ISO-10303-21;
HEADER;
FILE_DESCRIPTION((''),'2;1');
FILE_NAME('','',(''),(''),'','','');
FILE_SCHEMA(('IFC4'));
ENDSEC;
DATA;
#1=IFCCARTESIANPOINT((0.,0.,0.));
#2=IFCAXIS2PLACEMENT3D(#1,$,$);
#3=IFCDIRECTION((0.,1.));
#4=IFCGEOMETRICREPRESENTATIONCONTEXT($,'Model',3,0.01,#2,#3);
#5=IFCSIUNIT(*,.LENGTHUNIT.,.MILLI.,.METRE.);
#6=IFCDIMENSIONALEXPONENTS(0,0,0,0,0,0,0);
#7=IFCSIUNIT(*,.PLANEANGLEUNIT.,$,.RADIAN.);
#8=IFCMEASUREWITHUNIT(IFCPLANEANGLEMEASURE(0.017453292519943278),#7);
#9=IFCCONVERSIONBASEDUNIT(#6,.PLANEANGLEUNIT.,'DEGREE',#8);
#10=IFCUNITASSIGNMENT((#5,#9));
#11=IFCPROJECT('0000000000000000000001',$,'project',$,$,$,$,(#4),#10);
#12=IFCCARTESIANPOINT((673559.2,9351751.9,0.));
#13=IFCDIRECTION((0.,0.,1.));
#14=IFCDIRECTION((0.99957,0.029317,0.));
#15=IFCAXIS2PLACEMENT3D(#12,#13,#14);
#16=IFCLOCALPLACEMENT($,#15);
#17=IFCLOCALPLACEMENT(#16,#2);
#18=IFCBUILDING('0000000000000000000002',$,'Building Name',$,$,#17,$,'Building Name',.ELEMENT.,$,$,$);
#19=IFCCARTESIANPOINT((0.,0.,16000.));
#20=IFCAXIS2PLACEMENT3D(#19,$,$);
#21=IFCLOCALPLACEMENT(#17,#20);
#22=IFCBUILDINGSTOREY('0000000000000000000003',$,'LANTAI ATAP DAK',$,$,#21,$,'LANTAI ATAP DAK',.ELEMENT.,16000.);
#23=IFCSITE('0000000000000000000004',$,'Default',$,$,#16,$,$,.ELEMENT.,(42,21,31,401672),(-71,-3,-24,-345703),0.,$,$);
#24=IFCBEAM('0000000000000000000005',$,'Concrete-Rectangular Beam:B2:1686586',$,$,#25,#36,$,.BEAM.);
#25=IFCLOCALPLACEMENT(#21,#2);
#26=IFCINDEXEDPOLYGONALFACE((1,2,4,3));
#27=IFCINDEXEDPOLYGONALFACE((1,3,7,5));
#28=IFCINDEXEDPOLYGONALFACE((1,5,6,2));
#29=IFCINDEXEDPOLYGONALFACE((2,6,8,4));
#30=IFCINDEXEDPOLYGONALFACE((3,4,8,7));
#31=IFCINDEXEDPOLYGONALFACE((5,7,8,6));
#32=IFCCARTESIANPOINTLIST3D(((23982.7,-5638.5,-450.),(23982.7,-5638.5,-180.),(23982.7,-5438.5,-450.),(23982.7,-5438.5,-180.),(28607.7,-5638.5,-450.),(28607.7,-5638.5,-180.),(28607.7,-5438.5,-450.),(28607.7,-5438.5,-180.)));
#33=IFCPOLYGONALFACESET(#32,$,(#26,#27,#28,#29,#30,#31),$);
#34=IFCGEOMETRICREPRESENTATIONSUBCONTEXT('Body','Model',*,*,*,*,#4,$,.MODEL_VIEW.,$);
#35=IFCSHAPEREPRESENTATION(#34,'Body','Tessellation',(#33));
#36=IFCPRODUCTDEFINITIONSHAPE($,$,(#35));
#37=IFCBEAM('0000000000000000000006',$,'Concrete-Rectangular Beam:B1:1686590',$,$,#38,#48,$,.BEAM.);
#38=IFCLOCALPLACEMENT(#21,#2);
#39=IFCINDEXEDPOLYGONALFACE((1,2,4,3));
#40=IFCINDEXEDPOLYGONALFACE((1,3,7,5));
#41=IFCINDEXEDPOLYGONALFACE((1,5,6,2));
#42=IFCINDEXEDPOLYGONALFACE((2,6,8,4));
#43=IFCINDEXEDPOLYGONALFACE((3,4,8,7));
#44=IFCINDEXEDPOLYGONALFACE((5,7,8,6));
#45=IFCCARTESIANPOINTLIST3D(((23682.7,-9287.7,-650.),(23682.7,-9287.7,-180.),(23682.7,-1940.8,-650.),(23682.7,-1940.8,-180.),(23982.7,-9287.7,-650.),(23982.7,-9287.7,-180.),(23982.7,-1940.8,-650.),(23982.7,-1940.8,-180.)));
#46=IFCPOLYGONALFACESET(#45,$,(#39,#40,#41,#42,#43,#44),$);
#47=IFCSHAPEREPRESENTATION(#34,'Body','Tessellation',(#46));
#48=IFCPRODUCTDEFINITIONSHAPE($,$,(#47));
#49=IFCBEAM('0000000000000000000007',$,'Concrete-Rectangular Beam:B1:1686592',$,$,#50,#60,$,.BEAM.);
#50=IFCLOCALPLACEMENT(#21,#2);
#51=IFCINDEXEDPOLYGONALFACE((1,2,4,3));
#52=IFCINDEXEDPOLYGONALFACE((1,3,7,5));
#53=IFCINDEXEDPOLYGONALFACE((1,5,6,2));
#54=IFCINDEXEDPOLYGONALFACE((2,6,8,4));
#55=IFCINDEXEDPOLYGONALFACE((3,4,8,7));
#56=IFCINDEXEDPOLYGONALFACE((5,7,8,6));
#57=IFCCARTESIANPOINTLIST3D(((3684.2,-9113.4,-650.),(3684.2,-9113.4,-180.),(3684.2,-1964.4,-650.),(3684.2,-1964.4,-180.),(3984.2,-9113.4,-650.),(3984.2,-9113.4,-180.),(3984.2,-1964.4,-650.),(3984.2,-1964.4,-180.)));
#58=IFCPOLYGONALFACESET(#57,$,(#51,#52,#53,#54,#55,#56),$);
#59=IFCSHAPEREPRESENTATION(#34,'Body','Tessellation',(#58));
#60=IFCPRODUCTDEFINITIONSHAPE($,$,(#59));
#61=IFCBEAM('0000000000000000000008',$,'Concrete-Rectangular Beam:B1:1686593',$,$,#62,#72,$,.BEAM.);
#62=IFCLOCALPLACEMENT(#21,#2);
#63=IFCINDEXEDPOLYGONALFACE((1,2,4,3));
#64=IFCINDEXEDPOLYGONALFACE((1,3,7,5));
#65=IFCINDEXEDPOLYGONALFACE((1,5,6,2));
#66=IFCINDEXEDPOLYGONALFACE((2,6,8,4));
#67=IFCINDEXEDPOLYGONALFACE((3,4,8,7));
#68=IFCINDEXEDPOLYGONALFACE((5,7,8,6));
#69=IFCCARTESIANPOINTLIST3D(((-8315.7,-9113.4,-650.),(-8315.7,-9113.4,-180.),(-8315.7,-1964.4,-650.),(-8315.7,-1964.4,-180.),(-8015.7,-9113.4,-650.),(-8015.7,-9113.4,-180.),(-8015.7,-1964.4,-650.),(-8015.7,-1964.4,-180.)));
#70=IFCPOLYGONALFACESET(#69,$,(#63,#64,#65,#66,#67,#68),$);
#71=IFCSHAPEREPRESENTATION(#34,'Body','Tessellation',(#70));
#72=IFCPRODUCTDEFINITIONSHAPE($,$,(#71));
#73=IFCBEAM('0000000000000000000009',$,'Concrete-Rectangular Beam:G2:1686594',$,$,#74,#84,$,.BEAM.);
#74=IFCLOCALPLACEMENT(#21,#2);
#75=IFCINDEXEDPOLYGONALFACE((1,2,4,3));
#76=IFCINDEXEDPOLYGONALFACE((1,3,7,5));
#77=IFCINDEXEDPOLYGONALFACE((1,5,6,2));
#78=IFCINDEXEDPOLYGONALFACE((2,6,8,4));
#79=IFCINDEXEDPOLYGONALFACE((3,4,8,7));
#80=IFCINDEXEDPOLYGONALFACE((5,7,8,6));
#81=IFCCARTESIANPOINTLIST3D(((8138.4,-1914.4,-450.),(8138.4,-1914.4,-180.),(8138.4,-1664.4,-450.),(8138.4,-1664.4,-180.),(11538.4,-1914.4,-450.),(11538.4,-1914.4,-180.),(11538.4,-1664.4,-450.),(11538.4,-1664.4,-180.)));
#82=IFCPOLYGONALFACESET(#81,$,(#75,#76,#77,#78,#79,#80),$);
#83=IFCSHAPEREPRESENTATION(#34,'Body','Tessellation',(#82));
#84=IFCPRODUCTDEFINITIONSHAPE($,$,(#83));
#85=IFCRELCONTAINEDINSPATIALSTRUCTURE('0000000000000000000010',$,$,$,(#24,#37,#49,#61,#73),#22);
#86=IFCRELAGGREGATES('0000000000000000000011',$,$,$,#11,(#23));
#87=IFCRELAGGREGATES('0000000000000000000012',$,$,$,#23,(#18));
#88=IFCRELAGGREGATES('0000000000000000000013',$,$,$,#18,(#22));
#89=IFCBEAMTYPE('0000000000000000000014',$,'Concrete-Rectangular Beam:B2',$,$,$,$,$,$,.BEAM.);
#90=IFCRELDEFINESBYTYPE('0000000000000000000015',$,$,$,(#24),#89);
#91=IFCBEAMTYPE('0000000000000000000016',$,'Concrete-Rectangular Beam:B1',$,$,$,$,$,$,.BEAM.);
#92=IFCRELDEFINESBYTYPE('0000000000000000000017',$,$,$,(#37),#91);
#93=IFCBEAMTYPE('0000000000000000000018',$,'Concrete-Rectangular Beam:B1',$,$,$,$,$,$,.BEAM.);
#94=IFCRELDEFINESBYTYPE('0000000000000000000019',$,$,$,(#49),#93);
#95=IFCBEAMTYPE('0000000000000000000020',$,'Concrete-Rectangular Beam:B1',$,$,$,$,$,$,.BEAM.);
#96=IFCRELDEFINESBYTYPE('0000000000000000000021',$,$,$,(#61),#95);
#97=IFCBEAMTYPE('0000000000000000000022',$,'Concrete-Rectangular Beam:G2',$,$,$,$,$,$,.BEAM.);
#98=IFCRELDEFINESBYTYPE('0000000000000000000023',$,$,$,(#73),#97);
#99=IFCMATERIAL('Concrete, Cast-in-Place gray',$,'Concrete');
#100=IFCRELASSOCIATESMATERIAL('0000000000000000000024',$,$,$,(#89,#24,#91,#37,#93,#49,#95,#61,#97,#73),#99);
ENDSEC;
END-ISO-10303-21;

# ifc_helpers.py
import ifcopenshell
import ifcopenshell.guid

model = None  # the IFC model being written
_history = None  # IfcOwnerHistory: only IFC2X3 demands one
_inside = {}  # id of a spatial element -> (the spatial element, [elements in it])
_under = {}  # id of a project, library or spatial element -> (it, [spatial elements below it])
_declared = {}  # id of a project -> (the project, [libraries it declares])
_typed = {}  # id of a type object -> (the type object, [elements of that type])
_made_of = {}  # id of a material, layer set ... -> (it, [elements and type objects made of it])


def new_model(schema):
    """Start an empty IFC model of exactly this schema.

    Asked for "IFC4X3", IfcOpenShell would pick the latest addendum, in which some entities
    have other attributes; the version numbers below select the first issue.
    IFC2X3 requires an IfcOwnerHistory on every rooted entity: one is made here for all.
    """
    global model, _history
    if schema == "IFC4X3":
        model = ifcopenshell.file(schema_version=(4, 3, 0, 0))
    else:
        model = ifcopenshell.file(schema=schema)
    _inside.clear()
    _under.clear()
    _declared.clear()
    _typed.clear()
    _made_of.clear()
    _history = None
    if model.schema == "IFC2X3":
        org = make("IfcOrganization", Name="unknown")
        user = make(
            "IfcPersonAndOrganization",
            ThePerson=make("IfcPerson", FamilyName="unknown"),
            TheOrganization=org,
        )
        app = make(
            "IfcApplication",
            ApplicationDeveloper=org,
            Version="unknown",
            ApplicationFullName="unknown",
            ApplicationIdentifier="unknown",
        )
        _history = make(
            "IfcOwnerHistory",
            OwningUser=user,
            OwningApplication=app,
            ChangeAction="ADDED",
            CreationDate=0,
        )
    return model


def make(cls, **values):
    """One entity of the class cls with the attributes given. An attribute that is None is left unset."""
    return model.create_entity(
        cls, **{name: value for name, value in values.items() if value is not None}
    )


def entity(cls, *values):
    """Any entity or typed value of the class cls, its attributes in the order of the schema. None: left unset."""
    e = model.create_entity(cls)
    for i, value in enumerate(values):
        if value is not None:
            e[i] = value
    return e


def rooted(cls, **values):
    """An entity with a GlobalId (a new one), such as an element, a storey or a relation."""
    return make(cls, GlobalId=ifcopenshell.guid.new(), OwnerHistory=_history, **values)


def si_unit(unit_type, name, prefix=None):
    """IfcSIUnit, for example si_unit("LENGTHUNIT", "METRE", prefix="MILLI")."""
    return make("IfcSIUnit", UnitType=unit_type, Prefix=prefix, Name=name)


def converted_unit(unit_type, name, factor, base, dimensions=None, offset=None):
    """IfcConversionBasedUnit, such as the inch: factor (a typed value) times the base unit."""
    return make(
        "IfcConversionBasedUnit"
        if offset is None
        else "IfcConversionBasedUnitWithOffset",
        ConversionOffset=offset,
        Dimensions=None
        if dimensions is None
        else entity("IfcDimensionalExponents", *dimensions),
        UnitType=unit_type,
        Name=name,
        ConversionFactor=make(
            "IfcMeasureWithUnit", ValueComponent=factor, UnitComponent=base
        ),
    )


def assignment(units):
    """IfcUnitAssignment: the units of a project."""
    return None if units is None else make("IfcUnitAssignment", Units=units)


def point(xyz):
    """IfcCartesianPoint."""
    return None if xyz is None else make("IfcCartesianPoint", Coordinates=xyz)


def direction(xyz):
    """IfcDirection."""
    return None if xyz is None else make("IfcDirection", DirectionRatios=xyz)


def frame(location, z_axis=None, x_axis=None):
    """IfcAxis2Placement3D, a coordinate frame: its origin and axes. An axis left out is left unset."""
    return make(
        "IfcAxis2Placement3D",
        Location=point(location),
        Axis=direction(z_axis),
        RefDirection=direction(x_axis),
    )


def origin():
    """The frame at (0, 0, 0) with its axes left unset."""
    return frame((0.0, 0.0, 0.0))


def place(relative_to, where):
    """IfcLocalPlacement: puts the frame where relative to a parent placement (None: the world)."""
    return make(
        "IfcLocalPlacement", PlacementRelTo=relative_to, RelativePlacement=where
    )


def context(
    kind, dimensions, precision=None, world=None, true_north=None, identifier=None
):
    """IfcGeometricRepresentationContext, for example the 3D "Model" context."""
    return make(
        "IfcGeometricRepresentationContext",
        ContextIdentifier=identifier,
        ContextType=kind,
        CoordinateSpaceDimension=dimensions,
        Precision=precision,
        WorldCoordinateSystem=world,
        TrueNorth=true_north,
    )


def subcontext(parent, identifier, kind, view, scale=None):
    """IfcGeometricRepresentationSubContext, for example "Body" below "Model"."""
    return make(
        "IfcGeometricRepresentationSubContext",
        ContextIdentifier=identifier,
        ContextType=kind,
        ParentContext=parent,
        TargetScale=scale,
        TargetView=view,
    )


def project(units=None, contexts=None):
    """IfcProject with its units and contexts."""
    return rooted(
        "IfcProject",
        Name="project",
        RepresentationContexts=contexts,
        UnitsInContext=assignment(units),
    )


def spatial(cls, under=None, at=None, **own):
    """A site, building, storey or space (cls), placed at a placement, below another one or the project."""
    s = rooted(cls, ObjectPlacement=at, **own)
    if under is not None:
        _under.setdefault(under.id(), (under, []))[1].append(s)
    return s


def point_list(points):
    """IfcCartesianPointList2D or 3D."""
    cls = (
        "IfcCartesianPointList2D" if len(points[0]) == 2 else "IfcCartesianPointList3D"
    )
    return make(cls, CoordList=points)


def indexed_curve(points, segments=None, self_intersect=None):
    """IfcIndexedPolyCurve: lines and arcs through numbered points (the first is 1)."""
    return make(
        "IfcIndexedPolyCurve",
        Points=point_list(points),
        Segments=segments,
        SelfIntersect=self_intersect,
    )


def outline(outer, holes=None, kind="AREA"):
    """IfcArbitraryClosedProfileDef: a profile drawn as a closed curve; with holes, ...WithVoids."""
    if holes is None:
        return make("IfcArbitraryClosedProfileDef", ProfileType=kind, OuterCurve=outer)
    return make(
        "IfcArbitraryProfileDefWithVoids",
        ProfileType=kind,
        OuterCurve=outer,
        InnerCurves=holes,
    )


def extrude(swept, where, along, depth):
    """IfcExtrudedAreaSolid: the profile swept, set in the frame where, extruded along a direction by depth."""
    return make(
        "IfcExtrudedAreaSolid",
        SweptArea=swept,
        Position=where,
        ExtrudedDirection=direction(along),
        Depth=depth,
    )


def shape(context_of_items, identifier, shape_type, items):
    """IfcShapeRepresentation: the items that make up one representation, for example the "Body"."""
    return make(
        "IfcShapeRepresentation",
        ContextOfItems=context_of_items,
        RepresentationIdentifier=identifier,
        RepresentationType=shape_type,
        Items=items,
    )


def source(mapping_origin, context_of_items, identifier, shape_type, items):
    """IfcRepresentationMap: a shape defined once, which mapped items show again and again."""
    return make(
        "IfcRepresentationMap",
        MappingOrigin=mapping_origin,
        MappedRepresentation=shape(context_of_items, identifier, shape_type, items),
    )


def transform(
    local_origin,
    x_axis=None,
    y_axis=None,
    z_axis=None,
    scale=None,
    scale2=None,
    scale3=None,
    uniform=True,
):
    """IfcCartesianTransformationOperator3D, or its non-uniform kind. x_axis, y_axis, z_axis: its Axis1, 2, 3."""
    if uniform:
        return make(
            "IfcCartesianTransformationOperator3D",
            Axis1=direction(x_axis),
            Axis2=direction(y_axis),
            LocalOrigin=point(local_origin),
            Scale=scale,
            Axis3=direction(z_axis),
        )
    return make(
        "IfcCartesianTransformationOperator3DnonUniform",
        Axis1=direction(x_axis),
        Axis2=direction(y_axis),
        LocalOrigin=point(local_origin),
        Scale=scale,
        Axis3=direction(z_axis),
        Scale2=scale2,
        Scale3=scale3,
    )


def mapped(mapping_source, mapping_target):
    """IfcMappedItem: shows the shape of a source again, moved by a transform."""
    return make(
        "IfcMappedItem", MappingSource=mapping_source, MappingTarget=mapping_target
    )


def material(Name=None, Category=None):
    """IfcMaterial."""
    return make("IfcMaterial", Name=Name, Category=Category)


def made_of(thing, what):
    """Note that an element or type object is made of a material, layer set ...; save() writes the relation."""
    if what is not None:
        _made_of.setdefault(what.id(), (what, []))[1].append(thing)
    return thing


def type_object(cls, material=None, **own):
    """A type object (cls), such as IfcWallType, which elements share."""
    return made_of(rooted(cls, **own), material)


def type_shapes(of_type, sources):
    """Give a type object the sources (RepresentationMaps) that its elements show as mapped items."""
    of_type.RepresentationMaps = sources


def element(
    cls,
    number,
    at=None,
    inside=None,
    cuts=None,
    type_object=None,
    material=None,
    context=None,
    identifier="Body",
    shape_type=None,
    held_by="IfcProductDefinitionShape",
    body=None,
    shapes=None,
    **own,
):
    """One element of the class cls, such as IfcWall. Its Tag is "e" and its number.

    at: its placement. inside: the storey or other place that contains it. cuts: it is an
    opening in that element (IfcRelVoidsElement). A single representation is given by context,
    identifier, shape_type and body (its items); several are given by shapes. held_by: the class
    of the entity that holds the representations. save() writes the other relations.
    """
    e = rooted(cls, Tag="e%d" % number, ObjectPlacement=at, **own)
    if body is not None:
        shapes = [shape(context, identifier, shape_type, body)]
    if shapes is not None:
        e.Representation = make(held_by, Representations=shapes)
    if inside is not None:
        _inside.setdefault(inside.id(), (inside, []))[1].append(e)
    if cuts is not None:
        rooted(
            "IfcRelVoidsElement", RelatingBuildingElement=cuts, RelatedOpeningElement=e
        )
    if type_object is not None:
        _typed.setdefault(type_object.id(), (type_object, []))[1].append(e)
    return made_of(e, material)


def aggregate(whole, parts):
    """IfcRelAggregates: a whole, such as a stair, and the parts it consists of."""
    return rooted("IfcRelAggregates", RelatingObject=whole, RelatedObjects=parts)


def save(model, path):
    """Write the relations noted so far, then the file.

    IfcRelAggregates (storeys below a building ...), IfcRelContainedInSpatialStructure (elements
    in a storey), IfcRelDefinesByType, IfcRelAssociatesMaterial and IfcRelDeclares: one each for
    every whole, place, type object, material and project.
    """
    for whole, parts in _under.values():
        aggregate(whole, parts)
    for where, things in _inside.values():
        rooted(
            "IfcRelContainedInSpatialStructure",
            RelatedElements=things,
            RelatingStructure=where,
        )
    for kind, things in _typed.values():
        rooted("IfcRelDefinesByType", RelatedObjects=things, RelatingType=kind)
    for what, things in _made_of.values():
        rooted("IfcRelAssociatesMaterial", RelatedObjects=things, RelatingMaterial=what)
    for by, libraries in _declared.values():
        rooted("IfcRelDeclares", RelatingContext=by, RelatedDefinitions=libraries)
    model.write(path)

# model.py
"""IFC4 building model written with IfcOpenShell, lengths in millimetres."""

from ifc_helpers import new_model, entity, si_unit, converted_unit, direction, frame, origin, place, context, subcontext, project, spatial, indexed_curve, outline, extrude, source, transform, mapped, material, type_object, type_shapes, element, save


model = new_model("IFC4")

# Units and contexts
model_context = context("Model", 3, precision=0.01, world=origin(), true_north=direction((0.0, 1.0)))
body_context = subcontext(model_context, "Body", "Model", "MODEL_VIEW")
ifc_project = project(units=[si_unit("LENGTHUNIT", "METRE", prefix="MILLI"), converted_unit("PLANEANGLEUNIT", "DEGREE", entity("IfcPlaneAngleMeasure", 0.017453292519943278), si_unit("PLANEANGLEUNIT", "RADIAN"), dimensions=[0, 0, 0, 0, 0, 0, 0])], contexts=[model_context])

# Site, building, storey
site_placement = place(None, frame((673559.2, 9351751.9, 0.0), z_axis=(0.0, 0.0, 1.0), x_axis=(0.99957, 0.029317, 0.0)))
site = spatial("IfcSite", under=ifc_project, at=site_placement, Name="Default", CompositionType="ELEMENT", RefLatitude=(42, 21, 31, 401672), RefLongitude=(-71, -3, -24, -345703), RefElevation=0.0)
building_placement = place(site_placement, origin())
building = spatial("IfcBuilding", under=site, at=building_placement, Name="Building Name", LongName="Building Name", CompositionType="ELEMENT")
storey_placement = place(building_placement, frame((0.0, 0.0, 16000.0)))
storey = spatial("IfcBuildingStorey", under=building, at=storey_placement, Name="LANTAI ATAP DAK", LongName="LANTAI ATAP DAK", CompositionType="ELEMENT", Elevation=16000.0)

# Beams
ifc_material = material(Name="Concrete, Cast-in-Place gray", Category="Concrete")
beam_type_1 = type_object("IfcBeamType", Name="Concrete-Rectangular Beam:B2", PredefinedType="BEAM", material=ifc_material)
shared_shape_1 = source(origin(), body_context, "Body", "SweptSolid", [
    extrude(outline(indexed_curve([(-135.0, -100.0), (135.0, -100.0), (135.0, 100.0), (-135.0, 100.0), (-135.0, -100.0)], self_intersect=False)), frame((23982.7, -5538.5, 15685.0), z_axis=(1.0, 0.0, 0.0), x_axis=(0.0, 0.0, -1.0)), (0.0, 0.0, 1.0), 4625.0),
])
type_shapes(beam_type_1, [shared_shape_1])
beam_1_placement = place(storey_placement, frame((0.0, 0.0, -16000.0)))
element("IfcBeam", 1, at=beam_1_placement, inside=storey, type_object=beam_type_1, material=ifc_material, Name="Concrete-Rectangular Beam:B2:1686586", PredefinedType="BEAM", context=body_context, shape_type="MappedRepresentation", body=[
    mapped(shared_shape_1, transform((0.0, 0.0, 0.0), scale=1.0)),
])
beam_type_2 = type_object("IfcBeamType", Name="Concrete-Rectangular Beam:B1", PredefinedType="BEAM", material=ifc_material)
shared_shape_2 = source(origin(), body_context, "Body", "SweptSolid", [
    extrude(outline(indexed_curve([(-150.0, -235.0), (150.0, -235.0), (150.0, 235.0), (-150.0, 235.0), (-150.0, -235.0)], self_intersect=False)), frame((23832.7, -9287.7, 15585.0), z_axis=(0.0, 1.0, 0.0), x_axis=(-1.0, 0.0, 0.0)), (0.0, 0.0, 1.0), 7347.0),
])
type_shapes(beam_type_2, [shared_shape_2])
beam_2_placement = place(storey_placement, frame((0.0, 0.0, -16000.0)))
element("IfcBeam", 2, at=beam_2_placement, inside=storey, type_object=beam_type_2, material=ifc_material, Name="Concrete-Rectangular Beam:B1:1686590", PredefinedType="BEAM", context=body_context, shape_type="MappedRepresentation", body=[
    mapped(shared_shape_2, transform((0.0, 0.0, 0.0), scale=1.0)),
])
beam_type_3 = type_object("IfcBeamType", Name="Concrete-Rectangular Beam:B1", PredefinedType="BEAM", material=ifc_material)
shared_shape_3 = source(origin(), body_context, "Body", "SweptSolid", [
    extrude(outline(indexed_curve([(-150.0, -235.0), (150.0, -235.0), (150.0, 235.0), (-150.0, 235.0), (-150.0, -235.0)], self_intersect=False)), frame((3834.2, -9113.4, 15585.0), z_axis=(0.0, 1.0, 0.0), x_axis=(-1.0, 0.0, 0.0)), (0.0, 0.0, 1.0), 7149.0),
])
type_shapes(beam_type_3, [shared_shape_3])
beam_3_placement = place(storey_placement, frame((0.0, 0.0, -16000.0)))
element("IfcBeam", 3, at=beam_3_placement, inside=storey, type_object=beam_type_3, material=ifc_material, Name="Concrete-Rectangular Beam:B1:1686592", PredefinedType="BEAM", context=body_context, shape_type="MappedRepresentation", body=[
    mapped(shared_shape_3, transform((0.0, 0.0, 0.0), scale=1.0)),
])
beam_type_4 = type_object("IfcBeamType", Name="Concrete-Rectangular Beam:B1", PredefinedType="BEAM", material=ifc_material)
shared_shape_4 = source(origin(), body_context, "Body", "SweptSolid", [
    extrude(outline(indexed_curve([(-150.0, -235.0), (150.0, -235.0), (150.0, 235.0), (-150.0, 235.0), (-150.0, -235.0)], self_intersect=False)), frame((-8165.7, -9113.4, 15585.0), z_axis=(0.0, 1.0, 0.0), x_axis=(-1.0, 0.0, 0.0)), (0.0, 0.0, 1.0), 7149.0),
])
type_shapes(beam_type_4, [shared_shape_4])
beam_4_placement = place(storey_placement, frame((0.0, 0.0, -16000.0)))
element("IfcBeam", 4, at=beam_4_placement, inside=storey, type_object=beam_type_4, material=ifc_material, Name="Concrete-Rectangular Beam:B1:1686593", PredefinedType="BEAM", context=body_context, shape_type="MappedRepresentation", body=[
    mapped(shared_shape_4, transform((0.0, 0.0, 0.0), scale=1.0)),
])
beam_type_5 = type_object("IfcBeamType", Name="Concrete-Rectangular Beam:G2", PredefinedType="BEAM", material=ifc_material)
shared_shape_5 = source(origin(), body_context, "Body", "SweptSolid", [
    extrude(outline(indexed_curve([(-135.0, -125.0), (135.0, -125.0), (135.0, 125.0), (-135.0, 125.0), (-135.0, -125.0)], self_intersect=False)), frame((8138.4, -1789.4, 15685.0), z_axis=(1.0, 0.0, 0.0), x_axis=(0.0, 0.0, -1.0)), (0.0, 0.0, 1.0), 3400.0),
])
type_shapes(beam_type_5, [shared_shape_5])
beam_5_placement = place(storey_placement, frame((0.0, 0.0, -16000.0)))
element("IfcBeam", 5, at=beam_5_placement, inside=storey, type_object=beam_type_5, material=ifc_material, Name="Concrete-Rectangular Beam:G2:1686594", PredefinedType="BEAM", context=body_context, shape_type="MappedRepresentation", body=[
    mapped(shared_shape_5, transform((0.0, 0.0, 0.0), scale=1.0)),
])

save(model, "model.ifc")
